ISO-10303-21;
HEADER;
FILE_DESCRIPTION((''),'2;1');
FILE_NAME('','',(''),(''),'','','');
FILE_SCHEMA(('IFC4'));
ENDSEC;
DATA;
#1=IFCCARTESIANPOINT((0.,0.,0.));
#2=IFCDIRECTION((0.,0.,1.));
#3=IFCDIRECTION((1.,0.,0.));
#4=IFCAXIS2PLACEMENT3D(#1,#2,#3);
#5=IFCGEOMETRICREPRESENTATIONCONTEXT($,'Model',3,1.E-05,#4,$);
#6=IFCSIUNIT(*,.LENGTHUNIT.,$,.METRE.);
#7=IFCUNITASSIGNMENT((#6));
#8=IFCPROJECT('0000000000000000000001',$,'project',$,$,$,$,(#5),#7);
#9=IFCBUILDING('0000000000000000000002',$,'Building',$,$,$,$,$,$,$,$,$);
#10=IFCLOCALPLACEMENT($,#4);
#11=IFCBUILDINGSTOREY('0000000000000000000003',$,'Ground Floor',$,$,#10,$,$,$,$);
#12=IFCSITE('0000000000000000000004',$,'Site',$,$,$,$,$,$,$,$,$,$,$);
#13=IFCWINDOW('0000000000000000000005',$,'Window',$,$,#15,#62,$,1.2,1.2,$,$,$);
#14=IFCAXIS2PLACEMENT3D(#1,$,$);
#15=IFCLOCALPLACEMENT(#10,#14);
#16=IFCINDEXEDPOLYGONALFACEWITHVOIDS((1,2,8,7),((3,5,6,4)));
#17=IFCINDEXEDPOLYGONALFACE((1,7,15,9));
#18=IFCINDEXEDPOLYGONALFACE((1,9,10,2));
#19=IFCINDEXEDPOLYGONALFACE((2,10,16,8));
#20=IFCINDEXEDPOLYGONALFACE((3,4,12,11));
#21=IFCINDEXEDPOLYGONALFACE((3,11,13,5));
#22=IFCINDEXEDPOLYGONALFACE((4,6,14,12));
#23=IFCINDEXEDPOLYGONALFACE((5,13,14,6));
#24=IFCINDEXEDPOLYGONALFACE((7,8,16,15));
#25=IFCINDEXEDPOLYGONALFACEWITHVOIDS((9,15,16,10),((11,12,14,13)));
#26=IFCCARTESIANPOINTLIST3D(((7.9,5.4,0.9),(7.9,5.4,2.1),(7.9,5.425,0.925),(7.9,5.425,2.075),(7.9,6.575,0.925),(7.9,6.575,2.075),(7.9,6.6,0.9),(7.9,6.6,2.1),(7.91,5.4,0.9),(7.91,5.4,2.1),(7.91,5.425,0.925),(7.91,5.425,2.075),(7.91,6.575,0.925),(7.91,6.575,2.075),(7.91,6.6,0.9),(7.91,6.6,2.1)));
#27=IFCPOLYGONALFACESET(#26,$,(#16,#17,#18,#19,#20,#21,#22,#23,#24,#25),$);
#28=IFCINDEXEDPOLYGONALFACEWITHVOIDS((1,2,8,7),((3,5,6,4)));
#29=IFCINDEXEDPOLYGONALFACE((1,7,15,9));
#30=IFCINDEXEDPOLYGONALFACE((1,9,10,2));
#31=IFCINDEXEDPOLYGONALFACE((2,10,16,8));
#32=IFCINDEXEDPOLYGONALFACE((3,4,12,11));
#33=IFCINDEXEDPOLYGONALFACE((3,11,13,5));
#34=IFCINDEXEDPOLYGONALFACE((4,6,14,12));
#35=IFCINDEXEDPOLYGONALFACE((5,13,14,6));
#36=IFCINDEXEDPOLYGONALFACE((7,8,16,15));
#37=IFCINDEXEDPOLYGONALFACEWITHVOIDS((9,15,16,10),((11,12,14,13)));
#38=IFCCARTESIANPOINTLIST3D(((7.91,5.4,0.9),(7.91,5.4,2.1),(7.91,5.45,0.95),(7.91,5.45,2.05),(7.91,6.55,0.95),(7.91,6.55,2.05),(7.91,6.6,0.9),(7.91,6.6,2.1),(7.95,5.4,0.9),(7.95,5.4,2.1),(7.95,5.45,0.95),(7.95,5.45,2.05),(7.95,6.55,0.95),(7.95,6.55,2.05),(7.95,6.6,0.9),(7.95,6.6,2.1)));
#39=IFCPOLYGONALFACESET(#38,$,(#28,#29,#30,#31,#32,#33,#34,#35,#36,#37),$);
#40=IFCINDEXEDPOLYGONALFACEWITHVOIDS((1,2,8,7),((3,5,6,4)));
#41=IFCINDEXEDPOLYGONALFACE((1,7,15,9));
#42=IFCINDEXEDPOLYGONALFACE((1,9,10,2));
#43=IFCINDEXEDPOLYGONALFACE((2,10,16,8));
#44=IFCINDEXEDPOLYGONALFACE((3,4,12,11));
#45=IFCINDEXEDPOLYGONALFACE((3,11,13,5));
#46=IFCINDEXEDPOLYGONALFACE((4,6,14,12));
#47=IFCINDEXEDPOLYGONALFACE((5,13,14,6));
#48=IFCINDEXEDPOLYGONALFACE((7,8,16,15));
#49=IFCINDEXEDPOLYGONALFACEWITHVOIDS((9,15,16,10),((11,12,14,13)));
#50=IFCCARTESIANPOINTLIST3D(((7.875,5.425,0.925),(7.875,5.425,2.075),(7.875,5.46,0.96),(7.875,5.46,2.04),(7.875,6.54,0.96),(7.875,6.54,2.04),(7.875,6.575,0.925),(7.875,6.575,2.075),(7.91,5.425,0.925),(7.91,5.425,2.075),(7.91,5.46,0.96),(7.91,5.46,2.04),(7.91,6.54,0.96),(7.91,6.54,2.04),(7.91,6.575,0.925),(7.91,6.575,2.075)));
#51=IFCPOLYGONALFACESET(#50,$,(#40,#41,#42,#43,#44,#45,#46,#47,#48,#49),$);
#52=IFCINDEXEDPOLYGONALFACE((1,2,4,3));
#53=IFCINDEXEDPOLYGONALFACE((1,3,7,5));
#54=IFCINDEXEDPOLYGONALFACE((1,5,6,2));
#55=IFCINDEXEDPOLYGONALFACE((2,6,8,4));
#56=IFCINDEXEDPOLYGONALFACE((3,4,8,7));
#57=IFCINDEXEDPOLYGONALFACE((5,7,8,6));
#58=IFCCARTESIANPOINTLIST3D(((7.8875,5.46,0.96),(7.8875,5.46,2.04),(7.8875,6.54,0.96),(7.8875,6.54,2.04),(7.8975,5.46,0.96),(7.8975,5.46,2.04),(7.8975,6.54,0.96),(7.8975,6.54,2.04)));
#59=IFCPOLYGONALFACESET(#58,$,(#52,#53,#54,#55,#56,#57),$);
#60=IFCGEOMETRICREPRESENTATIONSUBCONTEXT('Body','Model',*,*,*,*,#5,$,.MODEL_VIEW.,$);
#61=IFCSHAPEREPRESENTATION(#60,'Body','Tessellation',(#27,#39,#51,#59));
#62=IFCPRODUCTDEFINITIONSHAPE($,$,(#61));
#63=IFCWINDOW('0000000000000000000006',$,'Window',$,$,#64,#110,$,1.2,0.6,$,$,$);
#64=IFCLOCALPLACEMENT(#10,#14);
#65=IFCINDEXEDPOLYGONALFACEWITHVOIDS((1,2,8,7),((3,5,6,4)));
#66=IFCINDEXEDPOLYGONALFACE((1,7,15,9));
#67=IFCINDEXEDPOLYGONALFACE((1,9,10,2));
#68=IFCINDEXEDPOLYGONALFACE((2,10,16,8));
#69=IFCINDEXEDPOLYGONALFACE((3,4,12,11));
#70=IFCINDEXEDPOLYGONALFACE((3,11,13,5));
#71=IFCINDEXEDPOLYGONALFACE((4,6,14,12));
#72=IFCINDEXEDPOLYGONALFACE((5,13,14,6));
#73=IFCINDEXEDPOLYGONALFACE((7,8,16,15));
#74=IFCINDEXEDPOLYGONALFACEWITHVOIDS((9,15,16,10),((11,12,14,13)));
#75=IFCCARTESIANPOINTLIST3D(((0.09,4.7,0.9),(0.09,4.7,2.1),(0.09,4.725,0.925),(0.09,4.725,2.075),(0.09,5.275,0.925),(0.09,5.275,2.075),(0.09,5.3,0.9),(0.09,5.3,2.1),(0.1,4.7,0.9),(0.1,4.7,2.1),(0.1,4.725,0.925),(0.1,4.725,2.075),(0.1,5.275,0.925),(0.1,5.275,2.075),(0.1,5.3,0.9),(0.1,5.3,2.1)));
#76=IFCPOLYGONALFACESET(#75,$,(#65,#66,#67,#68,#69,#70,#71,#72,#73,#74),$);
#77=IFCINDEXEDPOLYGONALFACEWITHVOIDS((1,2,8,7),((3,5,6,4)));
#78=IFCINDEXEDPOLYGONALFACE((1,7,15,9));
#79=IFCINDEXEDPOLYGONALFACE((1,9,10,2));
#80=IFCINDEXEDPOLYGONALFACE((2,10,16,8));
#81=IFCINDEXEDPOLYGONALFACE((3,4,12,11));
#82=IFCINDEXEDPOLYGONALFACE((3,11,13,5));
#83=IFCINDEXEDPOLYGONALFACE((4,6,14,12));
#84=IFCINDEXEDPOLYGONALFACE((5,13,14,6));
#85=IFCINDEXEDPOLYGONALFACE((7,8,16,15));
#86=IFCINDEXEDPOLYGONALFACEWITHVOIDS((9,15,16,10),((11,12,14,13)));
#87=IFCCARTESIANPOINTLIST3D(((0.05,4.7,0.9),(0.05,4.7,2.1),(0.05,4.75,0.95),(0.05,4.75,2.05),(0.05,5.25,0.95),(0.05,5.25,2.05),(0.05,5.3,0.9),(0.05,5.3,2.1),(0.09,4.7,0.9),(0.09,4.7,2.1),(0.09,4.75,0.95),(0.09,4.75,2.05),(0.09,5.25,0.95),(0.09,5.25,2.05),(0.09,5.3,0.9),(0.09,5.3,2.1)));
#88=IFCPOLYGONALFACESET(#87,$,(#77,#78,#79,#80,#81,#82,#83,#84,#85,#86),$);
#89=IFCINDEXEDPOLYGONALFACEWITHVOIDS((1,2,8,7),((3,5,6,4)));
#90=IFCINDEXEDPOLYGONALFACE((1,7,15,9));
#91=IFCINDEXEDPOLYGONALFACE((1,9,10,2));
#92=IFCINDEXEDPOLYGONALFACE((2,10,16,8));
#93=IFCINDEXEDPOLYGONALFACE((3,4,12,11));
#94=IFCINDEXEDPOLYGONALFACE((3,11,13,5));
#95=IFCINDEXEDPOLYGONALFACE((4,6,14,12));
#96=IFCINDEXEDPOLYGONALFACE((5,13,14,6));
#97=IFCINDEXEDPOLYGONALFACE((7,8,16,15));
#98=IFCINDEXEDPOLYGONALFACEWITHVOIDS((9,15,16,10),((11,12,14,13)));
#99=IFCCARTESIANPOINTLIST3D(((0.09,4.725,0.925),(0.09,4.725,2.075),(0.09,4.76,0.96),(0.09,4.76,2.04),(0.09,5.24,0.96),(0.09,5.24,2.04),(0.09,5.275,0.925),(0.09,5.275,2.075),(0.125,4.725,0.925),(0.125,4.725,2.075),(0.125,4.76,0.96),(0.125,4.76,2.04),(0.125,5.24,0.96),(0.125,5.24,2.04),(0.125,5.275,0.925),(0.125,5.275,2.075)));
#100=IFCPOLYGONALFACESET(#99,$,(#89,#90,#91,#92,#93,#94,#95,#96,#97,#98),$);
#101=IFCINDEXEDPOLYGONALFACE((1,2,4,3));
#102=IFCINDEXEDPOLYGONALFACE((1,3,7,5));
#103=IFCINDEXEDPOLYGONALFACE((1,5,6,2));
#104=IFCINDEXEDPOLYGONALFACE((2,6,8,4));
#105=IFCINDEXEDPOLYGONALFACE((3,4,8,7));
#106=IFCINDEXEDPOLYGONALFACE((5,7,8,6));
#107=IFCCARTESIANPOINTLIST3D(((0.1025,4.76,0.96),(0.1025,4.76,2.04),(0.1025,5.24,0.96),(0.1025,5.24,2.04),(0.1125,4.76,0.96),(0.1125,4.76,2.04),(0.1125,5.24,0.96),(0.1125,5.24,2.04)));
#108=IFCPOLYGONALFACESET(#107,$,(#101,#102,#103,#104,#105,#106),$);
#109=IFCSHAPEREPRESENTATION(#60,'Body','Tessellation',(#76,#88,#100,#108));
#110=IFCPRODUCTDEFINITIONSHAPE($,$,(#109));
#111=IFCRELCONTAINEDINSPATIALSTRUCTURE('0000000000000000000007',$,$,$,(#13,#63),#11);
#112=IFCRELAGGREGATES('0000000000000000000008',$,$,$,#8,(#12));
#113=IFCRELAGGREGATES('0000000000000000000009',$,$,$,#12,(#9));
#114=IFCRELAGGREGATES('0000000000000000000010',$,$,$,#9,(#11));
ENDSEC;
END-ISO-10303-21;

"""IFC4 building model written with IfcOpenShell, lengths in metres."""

from ifc_helpers import new_model, si_unit, frame, origin_with_axes, place, context, subcontext, project, spatial, line, indexed_curve, outline, extrude, element, save


model = new_model("IFC4")

# Units and contexts
model_context = context("Model", 3, precision=1e-05, world=origin_with_axes())
body_context = subcontext(model_context, "Body", "Model", "MODEL_VIEW")
ifc_project = project(units=[si_unit("LENGTHUNIT", "METRE")], contexts=[model_context])

# Site, building, storey
site = spatial("IfcSite", under=ifc_project, Name="Site")
building = spatial("IfcBuilding", under=site, Name="Building")
storey_placement = place(None, origin_with_axes())
storey = spatial("IfcBuildingStorey", under=building, at=storey_placement, Name="Ground Floor")

# Windows
for number, where, z_axis, x_axis, name in (
    (1, (8.0, 5.4, 0.9), (0.0, 0.0, 1.0), (0.0, 1.0, 0.0), "Window"),
):
    element("IfcWindow", number, at=place(storey_placement, frame(where, z_axis=z_axis, x_axis=x_axis)), inside=storey, Name=name, OverallHeight=1.2, OverallWidth=1.2, context=body_context, shape_type="SweptSolid", body=[
        extrude(outline(indexed_curve([(0.0, 0.0), (1.2, 0.0), (1.2, 1.2), (0.0, 1.2)], segments=[line(1, 2, 3, 4, 1)]), holes=[indexed_curve([(0.025, 0.025), (1.175, 0.025), (1.175, 1.175), (0.025, 1.175)], segments=[line(1, 2, 3, 4, 1)])]), frame((0.0, 0.09, 0.0), z_axis=(0.0, -1.0, 0.0), x_axis=(1.0, 0.0, 0.0)), (0.0, 0.0, -1.0), 0.01),
        extrude(outline(indexed_curve([(0.0, 0.0), (1.2, 0.0), (1.2, 1.2), (0.0, 1.2)], segments=[line(1, 2, 3, 4, 1)]), holes=[indexed_curve([(0.05, 0.05), (1.15, 0.05), (1.15, 1.15), (0.05, 1.15)], segments=[line(1, 2, 3, 4, 1)])]), frame((0.0, 0.05, 0.0), z_axis=(0.0, -1.0, 0.0), x_axis=(1.0, 0.0, 0.0)), (0.0, 0.0, -1.0), 0.04),
        extrude(outline(indexed_curve([(0.0, 0.0), (1.15, 0.0), (1.15, 1.15), (0.0, 1.15)], segments=[line(1, 2, 3, 4, 1)]), holes=[indexed_curve([(0.035, 0.035), (1.115, 0.035), (1.115, 1.115), (0.035, 1.115)], segments=[line(1, 2, 3, 4, 1)])]), frame((0.025, 0.09, 0.025), z_axis=(0.0, -1.0, 0.0), x_axis=(1.0, 0.0, 0.0)), (0.0, 0.0, -1.0), 0.035),
        extrude(outline(indexed_curve([(0.035, 0.035), (1.115, 0.035), (1.115, 1.115), (0.035, 1.115)], segments=[line(1, 2, 3, 4, 1)])), frame((0.025, 0.1025, 0.025), z_axis=(0.0, -1.0, 0.0), x_axis=(1.0, 0.0, 0.0)), (0.0, 0.0, -1.0), 0.01),
    ])
window_1_placement = place(storey_placement, frame((0.0, 5.3, 0.9), z_axis=(0.0, 0.0, 1.0), x_axis=(0.0, -1.0, 0.0)))
element("IfcWindow", 2, at=window_1_placement, inside=storey, Name="Window", OverallHeight=1.2, OverallWidth=0.6, context=body_context, shape_type="SweptSolid", body=[
    extrude(outline(indexed_curve([(0.0, 0.0), (0.6, 0.0), (0.6, 1.2), (0.0, 1.2)], segments=[line(1, 2, 3, 4, 1)]), holes=[indexed_curve([(0.025, 0.025), (0.575, 0.025), (0.575, 1.175), (0.025, 1.175)], segments=[line(1, 2, 3, 4, 1)])]), frame((0.0, 0.09, 0.0), z_axis=(0.0, -1.0, 0.0), x_axis=(1.0, 0.0, 0.0)), (0.0, 0.0, -1.0), 0.01),
    extrude(outline(indexed_curve([(0.0, 0.0), (0.6, 0.0), (0.6, 1.2), (0.0, 1.2)], segments=[line(1, 2, 3, 4, 1)]), holes=[indexed_curve([(0.05, 0.05), (0.55, 0.05), (0.55, 1.15), (0.05, 1.15)], segments=[line(1, 2, 3, 4, 1)])]), frame((0.0, 0.05, 0.0), z_axis=(0.0, -1.0, 0.0), x_axis=(1.0, 0.0, 0.0)), (0.0, 0.0, -1.0), 0.04),
    extrude(outline(indexed_curve([(0.0, 0.0), (0.55, 0.0), (0.55, 1.15), (0.0, 1.15)], segments=[line(1, 2, 3, 4, 1)]), holes=[indexed_curve([(0.035, 0.035), (0.515, 0.035), (0.515, 1.115), (0.035, 1.115)], segments=[line(1, 2, 3, 4, 1)])]), frame((0.025, 0.09, 0.025), z_axis=(0.0, -1.0, 0.0), x_axis=(1.0, 0.0, 0.0)), (0.0, 0.0, -1.0), 0.035),
    extrude(outline(indexed_curve([(0.035, 0.035), (0.515, 0.035), (0.515, 1.115), (0.035, 1.115)], segments=[line(1, 2, 3, 4, 1)])), frame((0.025, 0.1025, 0.025), z_axis=(0.0, -1.0, 0.0), x_axis=(1.0, 0.0, 0.0)), (0.0, 0.0, -1.0), 0.01),
])

save(model, "model.ifc")
